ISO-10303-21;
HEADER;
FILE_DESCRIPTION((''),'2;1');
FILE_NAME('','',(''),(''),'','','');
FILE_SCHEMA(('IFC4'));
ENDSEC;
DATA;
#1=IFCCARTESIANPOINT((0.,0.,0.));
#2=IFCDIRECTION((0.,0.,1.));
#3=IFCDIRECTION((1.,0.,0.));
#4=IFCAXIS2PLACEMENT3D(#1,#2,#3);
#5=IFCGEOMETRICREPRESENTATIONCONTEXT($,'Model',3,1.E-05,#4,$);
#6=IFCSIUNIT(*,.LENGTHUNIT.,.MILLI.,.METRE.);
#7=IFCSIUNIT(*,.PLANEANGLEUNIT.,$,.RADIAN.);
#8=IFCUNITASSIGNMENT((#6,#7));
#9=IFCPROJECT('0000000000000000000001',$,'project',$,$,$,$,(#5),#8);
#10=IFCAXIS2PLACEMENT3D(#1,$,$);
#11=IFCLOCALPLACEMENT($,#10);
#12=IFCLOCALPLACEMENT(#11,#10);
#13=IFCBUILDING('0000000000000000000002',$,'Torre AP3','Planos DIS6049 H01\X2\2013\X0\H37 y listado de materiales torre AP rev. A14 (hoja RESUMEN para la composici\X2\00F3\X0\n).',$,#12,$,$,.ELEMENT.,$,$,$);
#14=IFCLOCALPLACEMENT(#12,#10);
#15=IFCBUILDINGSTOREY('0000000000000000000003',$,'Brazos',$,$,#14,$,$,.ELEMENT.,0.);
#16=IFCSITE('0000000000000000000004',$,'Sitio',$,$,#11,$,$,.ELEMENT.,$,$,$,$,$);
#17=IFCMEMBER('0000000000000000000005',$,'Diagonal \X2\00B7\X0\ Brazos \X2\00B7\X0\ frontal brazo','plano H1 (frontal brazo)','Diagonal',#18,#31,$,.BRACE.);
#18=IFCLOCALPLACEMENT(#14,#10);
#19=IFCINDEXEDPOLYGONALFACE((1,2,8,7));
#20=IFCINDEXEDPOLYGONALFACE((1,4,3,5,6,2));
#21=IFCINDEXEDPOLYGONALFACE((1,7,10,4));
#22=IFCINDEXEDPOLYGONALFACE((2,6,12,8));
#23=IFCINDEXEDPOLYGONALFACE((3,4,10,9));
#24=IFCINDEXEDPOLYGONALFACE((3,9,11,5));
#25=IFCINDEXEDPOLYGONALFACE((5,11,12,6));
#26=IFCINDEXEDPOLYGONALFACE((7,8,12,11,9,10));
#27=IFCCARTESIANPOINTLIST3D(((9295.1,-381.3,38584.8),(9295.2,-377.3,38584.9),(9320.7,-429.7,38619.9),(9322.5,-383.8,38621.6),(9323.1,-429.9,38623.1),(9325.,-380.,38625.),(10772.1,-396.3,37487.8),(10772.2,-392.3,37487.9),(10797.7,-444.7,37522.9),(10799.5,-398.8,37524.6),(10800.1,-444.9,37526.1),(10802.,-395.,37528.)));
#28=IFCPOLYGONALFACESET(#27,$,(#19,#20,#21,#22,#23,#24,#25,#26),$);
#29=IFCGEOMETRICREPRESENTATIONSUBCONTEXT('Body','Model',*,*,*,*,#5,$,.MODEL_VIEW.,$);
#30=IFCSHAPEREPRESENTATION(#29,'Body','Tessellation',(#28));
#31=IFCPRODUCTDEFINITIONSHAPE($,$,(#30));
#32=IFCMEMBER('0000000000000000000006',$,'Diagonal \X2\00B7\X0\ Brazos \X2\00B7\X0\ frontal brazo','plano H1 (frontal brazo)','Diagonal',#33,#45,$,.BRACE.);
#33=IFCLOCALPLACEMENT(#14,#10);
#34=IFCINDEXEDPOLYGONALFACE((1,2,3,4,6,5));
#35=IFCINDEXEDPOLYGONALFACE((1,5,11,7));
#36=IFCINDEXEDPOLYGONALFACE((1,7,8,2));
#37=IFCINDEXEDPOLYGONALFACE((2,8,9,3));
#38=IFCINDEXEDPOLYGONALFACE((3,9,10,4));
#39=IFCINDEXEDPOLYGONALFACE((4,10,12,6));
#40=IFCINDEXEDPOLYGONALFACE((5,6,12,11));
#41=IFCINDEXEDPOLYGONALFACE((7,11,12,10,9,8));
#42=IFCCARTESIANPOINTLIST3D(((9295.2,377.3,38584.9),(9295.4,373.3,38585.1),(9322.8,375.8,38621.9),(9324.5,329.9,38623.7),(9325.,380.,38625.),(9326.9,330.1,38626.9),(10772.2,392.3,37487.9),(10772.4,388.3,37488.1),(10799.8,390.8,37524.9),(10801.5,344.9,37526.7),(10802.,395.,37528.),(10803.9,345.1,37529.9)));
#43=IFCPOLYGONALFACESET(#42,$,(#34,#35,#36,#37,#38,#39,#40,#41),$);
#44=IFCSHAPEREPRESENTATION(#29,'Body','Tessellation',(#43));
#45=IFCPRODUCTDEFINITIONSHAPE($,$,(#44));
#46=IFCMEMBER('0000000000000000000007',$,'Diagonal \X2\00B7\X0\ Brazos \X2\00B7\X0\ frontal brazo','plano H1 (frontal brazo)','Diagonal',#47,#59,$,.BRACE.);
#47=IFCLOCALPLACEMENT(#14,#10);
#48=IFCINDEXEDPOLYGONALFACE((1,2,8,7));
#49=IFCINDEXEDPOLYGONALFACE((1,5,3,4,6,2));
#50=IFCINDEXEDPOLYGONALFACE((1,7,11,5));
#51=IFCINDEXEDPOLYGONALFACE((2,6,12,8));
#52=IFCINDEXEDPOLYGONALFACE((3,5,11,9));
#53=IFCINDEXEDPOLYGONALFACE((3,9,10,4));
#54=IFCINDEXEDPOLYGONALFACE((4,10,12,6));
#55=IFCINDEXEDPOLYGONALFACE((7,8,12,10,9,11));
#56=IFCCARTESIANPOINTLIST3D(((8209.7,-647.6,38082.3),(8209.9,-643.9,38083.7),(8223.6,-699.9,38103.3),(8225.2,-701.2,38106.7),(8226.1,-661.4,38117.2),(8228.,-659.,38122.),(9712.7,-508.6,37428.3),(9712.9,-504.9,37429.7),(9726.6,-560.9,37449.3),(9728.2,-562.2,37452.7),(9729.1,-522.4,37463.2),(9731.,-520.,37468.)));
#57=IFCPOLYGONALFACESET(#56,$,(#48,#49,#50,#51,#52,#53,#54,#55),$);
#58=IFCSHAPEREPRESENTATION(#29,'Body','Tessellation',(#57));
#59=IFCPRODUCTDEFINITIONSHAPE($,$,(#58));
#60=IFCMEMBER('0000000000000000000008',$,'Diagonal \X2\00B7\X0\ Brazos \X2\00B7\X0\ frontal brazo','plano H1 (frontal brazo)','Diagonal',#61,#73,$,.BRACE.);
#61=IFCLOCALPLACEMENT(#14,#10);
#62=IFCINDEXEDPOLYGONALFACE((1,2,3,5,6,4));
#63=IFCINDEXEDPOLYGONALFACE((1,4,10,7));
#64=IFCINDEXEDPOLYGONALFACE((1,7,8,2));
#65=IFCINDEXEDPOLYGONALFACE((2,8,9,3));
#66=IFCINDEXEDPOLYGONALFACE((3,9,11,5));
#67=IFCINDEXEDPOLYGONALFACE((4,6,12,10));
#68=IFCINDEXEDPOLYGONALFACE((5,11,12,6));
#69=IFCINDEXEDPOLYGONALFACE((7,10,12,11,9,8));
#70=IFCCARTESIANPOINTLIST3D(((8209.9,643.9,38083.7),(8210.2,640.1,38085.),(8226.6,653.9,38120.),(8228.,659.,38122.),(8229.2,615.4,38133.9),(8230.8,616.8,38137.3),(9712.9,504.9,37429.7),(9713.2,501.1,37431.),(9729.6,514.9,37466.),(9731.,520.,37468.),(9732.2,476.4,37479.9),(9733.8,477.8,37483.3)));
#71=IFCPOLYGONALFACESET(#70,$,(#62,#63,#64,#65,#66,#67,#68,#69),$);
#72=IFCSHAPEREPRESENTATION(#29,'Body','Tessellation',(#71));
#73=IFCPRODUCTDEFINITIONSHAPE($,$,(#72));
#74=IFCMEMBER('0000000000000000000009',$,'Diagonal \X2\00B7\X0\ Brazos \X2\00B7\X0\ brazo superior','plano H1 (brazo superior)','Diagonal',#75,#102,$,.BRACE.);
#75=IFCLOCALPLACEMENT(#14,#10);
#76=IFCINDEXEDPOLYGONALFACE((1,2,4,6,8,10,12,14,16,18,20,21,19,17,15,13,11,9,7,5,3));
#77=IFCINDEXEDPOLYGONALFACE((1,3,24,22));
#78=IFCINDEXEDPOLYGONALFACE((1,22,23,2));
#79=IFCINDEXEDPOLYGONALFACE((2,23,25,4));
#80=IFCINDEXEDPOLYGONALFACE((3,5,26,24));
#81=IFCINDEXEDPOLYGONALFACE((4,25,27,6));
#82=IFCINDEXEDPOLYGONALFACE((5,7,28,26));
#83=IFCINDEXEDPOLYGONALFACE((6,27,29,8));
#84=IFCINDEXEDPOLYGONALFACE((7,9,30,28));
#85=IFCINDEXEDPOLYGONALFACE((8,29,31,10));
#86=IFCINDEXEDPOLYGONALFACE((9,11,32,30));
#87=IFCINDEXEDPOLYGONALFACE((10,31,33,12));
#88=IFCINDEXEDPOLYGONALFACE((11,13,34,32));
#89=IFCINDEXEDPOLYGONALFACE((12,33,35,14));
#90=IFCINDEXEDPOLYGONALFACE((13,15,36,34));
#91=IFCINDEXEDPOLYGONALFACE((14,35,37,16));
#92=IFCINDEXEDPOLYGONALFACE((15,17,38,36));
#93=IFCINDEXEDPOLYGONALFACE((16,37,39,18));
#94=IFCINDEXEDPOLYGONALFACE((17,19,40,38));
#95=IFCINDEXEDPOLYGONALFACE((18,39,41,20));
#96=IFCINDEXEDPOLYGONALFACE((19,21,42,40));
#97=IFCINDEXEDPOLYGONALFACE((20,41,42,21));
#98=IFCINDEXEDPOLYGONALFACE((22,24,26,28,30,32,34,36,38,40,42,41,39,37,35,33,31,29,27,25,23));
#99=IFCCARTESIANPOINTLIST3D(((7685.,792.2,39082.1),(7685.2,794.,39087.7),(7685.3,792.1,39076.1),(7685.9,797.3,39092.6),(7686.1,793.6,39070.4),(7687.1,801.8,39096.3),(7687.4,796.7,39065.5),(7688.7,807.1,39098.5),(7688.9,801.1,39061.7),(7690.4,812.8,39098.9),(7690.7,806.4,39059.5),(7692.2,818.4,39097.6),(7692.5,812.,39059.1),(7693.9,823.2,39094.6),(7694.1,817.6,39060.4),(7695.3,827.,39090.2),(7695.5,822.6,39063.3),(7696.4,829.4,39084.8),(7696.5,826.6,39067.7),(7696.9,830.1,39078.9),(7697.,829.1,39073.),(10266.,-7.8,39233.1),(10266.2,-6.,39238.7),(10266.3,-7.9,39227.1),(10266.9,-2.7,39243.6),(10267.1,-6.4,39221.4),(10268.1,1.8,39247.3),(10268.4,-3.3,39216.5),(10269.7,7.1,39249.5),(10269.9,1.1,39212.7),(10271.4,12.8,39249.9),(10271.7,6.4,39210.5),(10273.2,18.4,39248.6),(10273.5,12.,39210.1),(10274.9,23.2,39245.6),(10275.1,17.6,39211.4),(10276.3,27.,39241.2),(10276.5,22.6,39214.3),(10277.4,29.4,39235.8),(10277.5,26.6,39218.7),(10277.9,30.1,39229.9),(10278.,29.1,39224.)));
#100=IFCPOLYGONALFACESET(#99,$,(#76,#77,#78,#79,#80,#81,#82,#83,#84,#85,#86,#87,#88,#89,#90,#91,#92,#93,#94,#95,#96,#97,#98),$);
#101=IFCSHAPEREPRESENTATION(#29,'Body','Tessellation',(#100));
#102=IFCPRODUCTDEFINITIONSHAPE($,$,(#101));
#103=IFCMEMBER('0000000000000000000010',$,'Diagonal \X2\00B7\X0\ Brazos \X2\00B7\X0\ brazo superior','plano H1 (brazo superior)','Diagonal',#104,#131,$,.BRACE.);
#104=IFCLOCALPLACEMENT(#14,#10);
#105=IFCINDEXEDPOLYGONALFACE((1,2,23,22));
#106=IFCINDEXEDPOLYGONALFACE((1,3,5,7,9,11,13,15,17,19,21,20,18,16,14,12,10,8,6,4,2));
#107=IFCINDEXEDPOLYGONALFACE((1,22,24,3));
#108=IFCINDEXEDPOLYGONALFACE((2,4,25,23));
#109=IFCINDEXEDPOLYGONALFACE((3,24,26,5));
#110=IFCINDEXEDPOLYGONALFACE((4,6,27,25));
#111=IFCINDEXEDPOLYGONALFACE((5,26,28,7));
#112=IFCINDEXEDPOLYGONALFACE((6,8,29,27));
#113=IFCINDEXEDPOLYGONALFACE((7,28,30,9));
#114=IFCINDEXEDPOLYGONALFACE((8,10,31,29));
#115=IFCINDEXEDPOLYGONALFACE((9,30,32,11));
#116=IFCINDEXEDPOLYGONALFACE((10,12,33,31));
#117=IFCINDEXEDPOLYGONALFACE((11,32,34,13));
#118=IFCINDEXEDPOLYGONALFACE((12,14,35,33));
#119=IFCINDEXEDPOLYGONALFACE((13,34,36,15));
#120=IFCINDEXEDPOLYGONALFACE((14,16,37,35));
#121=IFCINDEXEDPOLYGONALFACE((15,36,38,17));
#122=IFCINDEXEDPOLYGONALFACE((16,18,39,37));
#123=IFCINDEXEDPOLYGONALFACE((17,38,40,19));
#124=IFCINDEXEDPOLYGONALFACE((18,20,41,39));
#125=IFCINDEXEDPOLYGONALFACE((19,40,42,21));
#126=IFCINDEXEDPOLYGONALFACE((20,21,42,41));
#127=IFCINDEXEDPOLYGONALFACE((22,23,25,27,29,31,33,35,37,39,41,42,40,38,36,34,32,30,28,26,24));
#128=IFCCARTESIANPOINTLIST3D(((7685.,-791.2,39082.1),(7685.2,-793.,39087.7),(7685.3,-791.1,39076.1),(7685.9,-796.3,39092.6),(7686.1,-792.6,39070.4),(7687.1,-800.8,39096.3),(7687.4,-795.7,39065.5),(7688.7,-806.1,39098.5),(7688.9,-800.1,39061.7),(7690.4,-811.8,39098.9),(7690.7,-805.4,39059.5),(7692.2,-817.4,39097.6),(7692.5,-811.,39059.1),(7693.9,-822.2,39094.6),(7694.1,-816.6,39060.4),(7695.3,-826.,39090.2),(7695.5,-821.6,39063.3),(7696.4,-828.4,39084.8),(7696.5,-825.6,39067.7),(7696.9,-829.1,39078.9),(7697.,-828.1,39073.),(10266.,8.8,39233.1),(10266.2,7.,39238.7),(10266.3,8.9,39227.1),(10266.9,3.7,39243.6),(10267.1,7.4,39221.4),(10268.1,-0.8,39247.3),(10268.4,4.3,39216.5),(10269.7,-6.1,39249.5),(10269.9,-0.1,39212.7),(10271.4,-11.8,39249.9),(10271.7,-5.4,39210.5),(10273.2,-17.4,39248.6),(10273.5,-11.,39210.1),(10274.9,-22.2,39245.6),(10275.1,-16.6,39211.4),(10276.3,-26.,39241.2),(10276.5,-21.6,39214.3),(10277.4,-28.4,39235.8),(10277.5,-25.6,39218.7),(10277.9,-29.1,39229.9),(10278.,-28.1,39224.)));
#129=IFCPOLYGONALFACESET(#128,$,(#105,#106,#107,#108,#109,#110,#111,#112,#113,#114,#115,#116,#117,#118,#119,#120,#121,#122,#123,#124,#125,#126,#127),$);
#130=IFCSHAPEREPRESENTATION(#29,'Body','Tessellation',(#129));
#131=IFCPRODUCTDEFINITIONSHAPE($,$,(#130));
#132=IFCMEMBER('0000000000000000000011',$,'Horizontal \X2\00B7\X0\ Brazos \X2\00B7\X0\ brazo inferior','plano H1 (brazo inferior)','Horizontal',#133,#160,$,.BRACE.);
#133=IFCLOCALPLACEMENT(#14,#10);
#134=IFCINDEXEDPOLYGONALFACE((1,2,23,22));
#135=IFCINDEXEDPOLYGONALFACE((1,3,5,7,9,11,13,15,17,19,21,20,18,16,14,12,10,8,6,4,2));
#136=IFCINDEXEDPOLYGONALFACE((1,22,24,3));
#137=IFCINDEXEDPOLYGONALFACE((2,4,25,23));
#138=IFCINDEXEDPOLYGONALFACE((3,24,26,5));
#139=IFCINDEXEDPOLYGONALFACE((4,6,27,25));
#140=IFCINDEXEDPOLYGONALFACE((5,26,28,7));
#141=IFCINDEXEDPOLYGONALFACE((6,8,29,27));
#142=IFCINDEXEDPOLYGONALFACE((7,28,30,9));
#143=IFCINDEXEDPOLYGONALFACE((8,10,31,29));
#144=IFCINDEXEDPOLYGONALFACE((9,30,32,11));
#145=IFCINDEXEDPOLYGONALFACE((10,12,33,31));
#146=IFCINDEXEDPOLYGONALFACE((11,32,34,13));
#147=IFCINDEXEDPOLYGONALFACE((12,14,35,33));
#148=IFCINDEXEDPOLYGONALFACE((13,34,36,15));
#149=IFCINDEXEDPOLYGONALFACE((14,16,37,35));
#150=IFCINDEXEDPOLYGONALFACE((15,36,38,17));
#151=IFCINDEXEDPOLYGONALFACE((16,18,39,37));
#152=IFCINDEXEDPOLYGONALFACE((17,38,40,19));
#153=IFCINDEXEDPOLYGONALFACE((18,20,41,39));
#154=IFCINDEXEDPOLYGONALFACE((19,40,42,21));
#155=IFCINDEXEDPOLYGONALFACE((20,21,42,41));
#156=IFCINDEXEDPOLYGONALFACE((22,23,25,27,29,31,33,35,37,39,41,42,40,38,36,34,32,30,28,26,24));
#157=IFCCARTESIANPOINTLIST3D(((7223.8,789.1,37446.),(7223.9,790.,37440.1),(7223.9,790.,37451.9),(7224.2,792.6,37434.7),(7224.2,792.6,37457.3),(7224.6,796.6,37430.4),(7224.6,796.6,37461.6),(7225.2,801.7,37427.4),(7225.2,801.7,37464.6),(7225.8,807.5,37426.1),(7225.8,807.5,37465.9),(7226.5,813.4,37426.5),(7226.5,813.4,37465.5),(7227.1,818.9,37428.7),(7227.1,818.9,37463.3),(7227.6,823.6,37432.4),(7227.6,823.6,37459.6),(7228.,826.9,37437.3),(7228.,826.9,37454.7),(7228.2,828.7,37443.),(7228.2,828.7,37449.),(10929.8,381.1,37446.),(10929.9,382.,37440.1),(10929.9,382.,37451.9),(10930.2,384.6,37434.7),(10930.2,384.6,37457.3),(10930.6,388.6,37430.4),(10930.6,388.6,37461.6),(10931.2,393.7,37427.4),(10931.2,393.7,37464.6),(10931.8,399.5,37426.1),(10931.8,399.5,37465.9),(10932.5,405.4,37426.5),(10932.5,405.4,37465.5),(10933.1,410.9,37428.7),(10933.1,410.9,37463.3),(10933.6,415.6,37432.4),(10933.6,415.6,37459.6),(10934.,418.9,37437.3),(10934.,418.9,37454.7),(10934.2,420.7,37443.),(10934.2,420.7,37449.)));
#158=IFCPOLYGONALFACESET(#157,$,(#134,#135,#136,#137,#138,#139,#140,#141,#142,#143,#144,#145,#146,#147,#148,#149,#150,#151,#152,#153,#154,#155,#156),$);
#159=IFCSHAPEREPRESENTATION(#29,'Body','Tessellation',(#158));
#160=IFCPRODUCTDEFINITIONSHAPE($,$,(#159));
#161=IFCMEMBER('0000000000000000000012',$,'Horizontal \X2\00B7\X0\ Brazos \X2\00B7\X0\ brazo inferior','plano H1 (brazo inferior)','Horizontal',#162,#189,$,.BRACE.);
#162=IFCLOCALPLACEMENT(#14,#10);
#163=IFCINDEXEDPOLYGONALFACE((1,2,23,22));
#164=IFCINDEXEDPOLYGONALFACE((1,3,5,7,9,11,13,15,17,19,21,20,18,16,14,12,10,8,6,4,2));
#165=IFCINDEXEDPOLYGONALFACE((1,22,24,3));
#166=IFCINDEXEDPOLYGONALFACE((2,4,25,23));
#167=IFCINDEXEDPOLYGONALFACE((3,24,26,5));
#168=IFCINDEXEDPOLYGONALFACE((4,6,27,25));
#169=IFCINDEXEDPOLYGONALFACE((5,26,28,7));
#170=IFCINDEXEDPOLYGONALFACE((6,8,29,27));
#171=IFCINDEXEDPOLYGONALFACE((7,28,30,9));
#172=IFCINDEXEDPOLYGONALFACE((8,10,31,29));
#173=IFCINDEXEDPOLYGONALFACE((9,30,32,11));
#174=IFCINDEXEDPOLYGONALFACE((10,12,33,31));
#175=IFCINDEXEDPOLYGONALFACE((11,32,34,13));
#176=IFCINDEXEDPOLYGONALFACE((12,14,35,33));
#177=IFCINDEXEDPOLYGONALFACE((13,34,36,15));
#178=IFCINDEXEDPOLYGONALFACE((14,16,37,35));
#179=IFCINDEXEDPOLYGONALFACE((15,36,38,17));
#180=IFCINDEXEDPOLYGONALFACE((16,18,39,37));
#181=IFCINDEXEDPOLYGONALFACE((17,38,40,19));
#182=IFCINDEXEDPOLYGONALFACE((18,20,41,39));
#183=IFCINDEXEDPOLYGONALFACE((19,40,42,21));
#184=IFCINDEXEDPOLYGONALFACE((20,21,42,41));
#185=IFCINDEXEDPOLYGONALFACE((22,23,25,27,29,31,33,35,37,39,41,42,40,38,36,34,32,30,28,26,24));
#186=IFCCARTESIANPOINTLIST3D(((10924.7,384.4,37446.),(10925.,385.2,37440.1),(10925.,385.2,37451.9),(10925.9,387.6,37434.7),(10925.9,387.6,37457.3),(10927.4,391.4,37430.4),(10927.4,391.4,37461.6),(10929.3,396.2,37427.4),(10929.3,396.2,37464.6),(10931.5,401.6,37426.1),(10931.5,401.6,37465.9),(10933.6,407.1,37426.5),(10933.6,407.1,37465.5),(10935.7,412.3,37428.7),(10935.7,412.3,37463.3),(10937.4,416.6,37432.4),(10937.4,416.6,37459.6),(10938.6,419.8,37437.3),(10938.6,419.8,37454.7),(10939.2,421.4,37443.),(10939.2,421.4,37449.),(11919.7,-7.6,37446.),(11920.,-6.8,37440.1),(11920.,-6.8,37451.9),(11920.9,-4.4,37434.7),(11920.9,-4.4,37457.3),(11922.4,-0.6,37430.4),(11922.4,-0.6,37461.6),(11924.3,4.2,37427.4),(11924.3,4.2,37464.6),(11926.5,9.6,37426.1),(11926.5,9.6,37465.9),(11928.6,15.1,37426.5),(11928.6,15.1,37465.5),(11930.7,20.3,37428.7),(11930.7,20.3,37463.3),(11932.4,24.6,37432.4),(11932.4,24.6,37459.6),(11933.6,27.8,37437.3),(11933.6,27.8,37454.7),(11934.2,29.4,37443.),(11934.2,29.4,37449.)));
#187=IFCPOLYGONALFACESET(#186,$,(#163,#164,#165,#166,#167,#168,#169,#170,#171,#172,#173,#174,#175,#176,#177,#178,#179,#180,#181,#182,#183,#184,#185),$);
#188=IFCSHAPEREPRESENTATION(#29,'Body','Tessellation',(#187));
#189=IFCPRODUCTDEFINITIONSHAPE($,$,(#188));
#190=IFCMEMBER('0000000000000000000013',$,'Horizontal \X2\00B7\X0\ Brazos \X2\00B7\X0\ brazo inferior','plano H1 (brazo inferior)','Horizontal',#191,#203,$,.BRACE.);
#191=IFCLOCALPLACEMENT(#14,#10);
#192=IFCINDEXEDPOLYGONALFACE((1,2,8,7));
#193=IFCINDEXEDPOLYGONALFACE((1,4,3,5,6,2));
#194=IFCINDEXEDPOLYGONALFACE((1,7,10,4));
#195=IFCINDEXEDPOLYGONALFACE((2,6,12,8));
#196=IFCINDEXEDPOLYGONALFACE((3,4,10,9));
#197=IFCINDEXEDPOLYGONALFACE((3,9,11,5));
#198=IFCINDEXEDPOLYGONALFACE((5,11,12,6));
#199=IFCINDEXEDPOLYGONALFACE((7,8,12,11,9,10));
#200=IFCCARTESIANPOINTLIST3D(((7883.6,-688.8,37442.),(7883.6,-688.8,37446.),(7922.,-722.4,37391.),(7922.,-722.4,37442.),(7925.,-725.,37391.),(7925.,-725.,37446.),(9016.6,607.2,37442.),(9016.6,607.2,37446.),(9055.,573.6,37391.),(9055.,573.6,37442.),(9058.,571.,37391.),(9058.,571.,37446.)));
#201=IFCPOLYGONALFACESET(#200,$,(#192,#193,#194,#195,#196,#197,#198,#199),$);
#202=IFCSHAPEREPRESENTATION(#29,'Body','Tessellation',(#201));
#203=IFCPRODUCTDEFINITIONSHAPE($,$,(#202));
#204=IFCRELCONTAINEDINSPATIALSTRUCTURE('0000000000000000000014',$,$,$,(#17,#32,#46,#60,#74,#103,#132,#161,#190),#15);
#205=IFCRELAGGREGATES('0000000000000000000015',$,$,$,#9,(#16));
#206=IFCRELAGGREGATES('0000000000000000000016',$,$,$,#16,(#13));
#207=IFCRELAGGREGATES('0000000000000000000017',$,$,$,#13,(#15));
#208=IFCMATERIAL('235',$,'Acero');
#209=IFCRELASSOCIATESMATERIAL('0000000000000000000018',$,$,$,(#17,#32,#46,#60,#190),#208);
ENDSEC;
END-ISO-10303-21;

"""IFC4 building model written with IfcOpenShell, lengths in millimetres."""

from ifc_helpers import new_model, si_unit, frame, frame_2d, origin, origin_with_axes, place, context, subcontext, project, spatial, circle, l_section, extrude, material, element, save


model = new_model("IFC4")

# Units and contexts
model_context = context("Model", 3, precision=1e-05, world=origin_with_axes())
body_context = subcontext(model_context, "Body", "Model", "MODEL_VIEW")
ifc_project = project(units=[si_unit("LENGTHUNIT", "METRE", prefix="MILLI"), si_unit("PLANEANGLEUNIT", "RADIAN")], contexts=[model_context])

# Site, building, storey
site_placement = place(None, origin())
site = spatial("IfcSite", under=ifc_project, at=site_placement, Name="Sitio", CompositionType="ELEMENT")
building_placement = place(site_placement, origin())
building = spatial("IfcBuilding", under=site, at=building_placement, Name="Torre AP3", Description="Planos DIS6049 H01–H37 y listado de materiales torre AP rev. A14 (hoja RESUMEN para la composición).", CompositionType="ELEMENT")
storey_placement = place(building_placement, origin())
storey = spatial("IfcBuildingStorey", under=building, at=storey_placement, Name="Brazos", CompositionType="ELEMENT", Elevation=0.0)

# Members
ifc_material_1 = material(Name="235", Category="Acero")
for number, where, z_axis, x_axis, name in (
    (1, (10802.0, -395.0, 37528.0), (-0.802769, 0.008153, 0.596234), (-0.595049, 0.053521, -0.801905), "Diagonal · Brazos · frontal brazo"),
    (2, (10802.0, 395.0, 37528.0), (-0.802769, -0.008153, 0.596234), (-0.595049, -0.053521, -0.801905), "Diagonal · Brazos · frontal brazo"),
):
    element("IfcMember", number, at=place(storey_placement, frame(where, z_axis=z_axis, x_axis=x_axis)), inside=storey, material=ifc_material_1, Name=name, Description="plano H1 (frontal brazo)", ObjectType="Diagonal", PredefinedType="BRACE", context=body_context, shape_type="SweptSolid", body=[
        extrude(l_section(Depth=50.0, Width=50.0, Thickness=4.0, at=frame_2d((25.0, 25.0))), None, (0.0, 0.0, 1.0), 1839.9),
    ])
for number, where, z_axis, x_axis, name in (
    (3, (9731.0, -520.0, 37468.0), (-0.913674, -0.084498, 0.397567), (-0.401755, 0.335963, -0.851893), "Diagonal · Brazos · frontal brazo"),
    (4, (9731.0, 520.0, 37468.0), (-0.913674, 0.084498, 0.397567), (-0.401755, -0.335963, -0.851893), "Diagonal · Brazos · frontal brazo"),
):
    element("IfcMember", number, at=place(storey_placement, frame(where, z_axis=z_axis, x_axis=x_axis)), inside=storey, material=ifc_material_1, Name=name, Description="plano H1 (frontal brazo)", ObjectType="Diagonal", PredefinedType="BRACE", context=body_context, shape_type="SweptSolid", body=[
        extrude(l_section(Depth=45.0, Width=45.0, Thickness=4.0, at=frame_2d((22.5, 22.5))), None, (0.0, 0.0, 1.0), 1645.0),
    ])
for number, where, z_axis, x_axis, name in (
    (5, (7691.0, 811.0, 39079.0), (0.953681, -0.2956, 0.055795), (-0.300728, -0.941427, 0.152572), "Diagonal · Brazos · brazo superior"),
    (6, (10272.0, -10.0, 39230.0), (-0.953681, -0.2956, -0.055795), (-0.300729, 0.941418, 0.152624), "Diagonal · Brazos · brazo superior"),
):
    element("IfcMember", number, at=place(storey_placement, frame(where, z_axis=z_axis, x_axis=x_axis)), inside=storey, Name=name, Description="plano H1 (brazo superior)", ObjectType="Diagonal", PredefinedType="BRACE", context=body_context, shape_type="SweptSolid", body=[
        extrude(circle(Radius=20.0), None, (0.0, 0.0, 1.0), 2706.4),
    ])
member_1_placement = place(storey_placement, frame((7226.0, 809.0, 37446.0), z_axis=(0.993994, -0.109431, 0.0), x_axis=(-0.109431, -0.993994, 0.0)))
element("IfcMember", 7, at=member_1_placement, inside=storey, Name="Horizontal · Brazos · brazo inferior", Description="plano H1 (brazo inferior)", ObjectType="Horizontal", PredefinedType="BRACE", context=body_context, shape_type="SweptSolid", body=[
    extrude(circle(Radius=20.0), None, (0.0, 0.0, 1.0), 3728.4),
])
member_2_placement = place(storey_placement, frame((10932.0, 403.0, 37446.0), z_axis=(0.930399, -0.366549, 0.0), x_axis=(-0.366549, -0.930399, 0.0)))
element("IfcMember", 8, at=member_2_placement, inside=storey, Name="Horizontal · Brazos · brazo inferior", Description="plano H1 (brazo inferior)", ObjectType="Horizontal", PredefinedType="BRACE", context=body_context, shape_type="SweptSolid", body=[
    extrude(circle(Radius=20.0), None, (0.0, 0.0, 1.0), 1069.4),
])
member_3_placement = place(storey_placement, frame((9058.0, 571.0, 37446.0), z_axis=(-0.658176, -0.752865, 0.0), x_axis=(-0.752865, 0.658176, 0.0)))
element("IfcMember", 9, at=member_3_placement, inside=storey, material=ifc_material_1, Name="Horizontal · Brazos · brazo inferior", Description="plano H1 (brazo inferior)", ObjectType="Horizontal", PredefinedType="BRACE", context=body_context, shape_type="SweptSolid", body=[
    extrude(l_section(Depth=55.0, Width=55.0, Thickness=4.0, at=frame_2d((27.5, 27.5))), None, (0.0, 0.0, 1.0), 1721.4),
])

save(model, "model.ifc")
